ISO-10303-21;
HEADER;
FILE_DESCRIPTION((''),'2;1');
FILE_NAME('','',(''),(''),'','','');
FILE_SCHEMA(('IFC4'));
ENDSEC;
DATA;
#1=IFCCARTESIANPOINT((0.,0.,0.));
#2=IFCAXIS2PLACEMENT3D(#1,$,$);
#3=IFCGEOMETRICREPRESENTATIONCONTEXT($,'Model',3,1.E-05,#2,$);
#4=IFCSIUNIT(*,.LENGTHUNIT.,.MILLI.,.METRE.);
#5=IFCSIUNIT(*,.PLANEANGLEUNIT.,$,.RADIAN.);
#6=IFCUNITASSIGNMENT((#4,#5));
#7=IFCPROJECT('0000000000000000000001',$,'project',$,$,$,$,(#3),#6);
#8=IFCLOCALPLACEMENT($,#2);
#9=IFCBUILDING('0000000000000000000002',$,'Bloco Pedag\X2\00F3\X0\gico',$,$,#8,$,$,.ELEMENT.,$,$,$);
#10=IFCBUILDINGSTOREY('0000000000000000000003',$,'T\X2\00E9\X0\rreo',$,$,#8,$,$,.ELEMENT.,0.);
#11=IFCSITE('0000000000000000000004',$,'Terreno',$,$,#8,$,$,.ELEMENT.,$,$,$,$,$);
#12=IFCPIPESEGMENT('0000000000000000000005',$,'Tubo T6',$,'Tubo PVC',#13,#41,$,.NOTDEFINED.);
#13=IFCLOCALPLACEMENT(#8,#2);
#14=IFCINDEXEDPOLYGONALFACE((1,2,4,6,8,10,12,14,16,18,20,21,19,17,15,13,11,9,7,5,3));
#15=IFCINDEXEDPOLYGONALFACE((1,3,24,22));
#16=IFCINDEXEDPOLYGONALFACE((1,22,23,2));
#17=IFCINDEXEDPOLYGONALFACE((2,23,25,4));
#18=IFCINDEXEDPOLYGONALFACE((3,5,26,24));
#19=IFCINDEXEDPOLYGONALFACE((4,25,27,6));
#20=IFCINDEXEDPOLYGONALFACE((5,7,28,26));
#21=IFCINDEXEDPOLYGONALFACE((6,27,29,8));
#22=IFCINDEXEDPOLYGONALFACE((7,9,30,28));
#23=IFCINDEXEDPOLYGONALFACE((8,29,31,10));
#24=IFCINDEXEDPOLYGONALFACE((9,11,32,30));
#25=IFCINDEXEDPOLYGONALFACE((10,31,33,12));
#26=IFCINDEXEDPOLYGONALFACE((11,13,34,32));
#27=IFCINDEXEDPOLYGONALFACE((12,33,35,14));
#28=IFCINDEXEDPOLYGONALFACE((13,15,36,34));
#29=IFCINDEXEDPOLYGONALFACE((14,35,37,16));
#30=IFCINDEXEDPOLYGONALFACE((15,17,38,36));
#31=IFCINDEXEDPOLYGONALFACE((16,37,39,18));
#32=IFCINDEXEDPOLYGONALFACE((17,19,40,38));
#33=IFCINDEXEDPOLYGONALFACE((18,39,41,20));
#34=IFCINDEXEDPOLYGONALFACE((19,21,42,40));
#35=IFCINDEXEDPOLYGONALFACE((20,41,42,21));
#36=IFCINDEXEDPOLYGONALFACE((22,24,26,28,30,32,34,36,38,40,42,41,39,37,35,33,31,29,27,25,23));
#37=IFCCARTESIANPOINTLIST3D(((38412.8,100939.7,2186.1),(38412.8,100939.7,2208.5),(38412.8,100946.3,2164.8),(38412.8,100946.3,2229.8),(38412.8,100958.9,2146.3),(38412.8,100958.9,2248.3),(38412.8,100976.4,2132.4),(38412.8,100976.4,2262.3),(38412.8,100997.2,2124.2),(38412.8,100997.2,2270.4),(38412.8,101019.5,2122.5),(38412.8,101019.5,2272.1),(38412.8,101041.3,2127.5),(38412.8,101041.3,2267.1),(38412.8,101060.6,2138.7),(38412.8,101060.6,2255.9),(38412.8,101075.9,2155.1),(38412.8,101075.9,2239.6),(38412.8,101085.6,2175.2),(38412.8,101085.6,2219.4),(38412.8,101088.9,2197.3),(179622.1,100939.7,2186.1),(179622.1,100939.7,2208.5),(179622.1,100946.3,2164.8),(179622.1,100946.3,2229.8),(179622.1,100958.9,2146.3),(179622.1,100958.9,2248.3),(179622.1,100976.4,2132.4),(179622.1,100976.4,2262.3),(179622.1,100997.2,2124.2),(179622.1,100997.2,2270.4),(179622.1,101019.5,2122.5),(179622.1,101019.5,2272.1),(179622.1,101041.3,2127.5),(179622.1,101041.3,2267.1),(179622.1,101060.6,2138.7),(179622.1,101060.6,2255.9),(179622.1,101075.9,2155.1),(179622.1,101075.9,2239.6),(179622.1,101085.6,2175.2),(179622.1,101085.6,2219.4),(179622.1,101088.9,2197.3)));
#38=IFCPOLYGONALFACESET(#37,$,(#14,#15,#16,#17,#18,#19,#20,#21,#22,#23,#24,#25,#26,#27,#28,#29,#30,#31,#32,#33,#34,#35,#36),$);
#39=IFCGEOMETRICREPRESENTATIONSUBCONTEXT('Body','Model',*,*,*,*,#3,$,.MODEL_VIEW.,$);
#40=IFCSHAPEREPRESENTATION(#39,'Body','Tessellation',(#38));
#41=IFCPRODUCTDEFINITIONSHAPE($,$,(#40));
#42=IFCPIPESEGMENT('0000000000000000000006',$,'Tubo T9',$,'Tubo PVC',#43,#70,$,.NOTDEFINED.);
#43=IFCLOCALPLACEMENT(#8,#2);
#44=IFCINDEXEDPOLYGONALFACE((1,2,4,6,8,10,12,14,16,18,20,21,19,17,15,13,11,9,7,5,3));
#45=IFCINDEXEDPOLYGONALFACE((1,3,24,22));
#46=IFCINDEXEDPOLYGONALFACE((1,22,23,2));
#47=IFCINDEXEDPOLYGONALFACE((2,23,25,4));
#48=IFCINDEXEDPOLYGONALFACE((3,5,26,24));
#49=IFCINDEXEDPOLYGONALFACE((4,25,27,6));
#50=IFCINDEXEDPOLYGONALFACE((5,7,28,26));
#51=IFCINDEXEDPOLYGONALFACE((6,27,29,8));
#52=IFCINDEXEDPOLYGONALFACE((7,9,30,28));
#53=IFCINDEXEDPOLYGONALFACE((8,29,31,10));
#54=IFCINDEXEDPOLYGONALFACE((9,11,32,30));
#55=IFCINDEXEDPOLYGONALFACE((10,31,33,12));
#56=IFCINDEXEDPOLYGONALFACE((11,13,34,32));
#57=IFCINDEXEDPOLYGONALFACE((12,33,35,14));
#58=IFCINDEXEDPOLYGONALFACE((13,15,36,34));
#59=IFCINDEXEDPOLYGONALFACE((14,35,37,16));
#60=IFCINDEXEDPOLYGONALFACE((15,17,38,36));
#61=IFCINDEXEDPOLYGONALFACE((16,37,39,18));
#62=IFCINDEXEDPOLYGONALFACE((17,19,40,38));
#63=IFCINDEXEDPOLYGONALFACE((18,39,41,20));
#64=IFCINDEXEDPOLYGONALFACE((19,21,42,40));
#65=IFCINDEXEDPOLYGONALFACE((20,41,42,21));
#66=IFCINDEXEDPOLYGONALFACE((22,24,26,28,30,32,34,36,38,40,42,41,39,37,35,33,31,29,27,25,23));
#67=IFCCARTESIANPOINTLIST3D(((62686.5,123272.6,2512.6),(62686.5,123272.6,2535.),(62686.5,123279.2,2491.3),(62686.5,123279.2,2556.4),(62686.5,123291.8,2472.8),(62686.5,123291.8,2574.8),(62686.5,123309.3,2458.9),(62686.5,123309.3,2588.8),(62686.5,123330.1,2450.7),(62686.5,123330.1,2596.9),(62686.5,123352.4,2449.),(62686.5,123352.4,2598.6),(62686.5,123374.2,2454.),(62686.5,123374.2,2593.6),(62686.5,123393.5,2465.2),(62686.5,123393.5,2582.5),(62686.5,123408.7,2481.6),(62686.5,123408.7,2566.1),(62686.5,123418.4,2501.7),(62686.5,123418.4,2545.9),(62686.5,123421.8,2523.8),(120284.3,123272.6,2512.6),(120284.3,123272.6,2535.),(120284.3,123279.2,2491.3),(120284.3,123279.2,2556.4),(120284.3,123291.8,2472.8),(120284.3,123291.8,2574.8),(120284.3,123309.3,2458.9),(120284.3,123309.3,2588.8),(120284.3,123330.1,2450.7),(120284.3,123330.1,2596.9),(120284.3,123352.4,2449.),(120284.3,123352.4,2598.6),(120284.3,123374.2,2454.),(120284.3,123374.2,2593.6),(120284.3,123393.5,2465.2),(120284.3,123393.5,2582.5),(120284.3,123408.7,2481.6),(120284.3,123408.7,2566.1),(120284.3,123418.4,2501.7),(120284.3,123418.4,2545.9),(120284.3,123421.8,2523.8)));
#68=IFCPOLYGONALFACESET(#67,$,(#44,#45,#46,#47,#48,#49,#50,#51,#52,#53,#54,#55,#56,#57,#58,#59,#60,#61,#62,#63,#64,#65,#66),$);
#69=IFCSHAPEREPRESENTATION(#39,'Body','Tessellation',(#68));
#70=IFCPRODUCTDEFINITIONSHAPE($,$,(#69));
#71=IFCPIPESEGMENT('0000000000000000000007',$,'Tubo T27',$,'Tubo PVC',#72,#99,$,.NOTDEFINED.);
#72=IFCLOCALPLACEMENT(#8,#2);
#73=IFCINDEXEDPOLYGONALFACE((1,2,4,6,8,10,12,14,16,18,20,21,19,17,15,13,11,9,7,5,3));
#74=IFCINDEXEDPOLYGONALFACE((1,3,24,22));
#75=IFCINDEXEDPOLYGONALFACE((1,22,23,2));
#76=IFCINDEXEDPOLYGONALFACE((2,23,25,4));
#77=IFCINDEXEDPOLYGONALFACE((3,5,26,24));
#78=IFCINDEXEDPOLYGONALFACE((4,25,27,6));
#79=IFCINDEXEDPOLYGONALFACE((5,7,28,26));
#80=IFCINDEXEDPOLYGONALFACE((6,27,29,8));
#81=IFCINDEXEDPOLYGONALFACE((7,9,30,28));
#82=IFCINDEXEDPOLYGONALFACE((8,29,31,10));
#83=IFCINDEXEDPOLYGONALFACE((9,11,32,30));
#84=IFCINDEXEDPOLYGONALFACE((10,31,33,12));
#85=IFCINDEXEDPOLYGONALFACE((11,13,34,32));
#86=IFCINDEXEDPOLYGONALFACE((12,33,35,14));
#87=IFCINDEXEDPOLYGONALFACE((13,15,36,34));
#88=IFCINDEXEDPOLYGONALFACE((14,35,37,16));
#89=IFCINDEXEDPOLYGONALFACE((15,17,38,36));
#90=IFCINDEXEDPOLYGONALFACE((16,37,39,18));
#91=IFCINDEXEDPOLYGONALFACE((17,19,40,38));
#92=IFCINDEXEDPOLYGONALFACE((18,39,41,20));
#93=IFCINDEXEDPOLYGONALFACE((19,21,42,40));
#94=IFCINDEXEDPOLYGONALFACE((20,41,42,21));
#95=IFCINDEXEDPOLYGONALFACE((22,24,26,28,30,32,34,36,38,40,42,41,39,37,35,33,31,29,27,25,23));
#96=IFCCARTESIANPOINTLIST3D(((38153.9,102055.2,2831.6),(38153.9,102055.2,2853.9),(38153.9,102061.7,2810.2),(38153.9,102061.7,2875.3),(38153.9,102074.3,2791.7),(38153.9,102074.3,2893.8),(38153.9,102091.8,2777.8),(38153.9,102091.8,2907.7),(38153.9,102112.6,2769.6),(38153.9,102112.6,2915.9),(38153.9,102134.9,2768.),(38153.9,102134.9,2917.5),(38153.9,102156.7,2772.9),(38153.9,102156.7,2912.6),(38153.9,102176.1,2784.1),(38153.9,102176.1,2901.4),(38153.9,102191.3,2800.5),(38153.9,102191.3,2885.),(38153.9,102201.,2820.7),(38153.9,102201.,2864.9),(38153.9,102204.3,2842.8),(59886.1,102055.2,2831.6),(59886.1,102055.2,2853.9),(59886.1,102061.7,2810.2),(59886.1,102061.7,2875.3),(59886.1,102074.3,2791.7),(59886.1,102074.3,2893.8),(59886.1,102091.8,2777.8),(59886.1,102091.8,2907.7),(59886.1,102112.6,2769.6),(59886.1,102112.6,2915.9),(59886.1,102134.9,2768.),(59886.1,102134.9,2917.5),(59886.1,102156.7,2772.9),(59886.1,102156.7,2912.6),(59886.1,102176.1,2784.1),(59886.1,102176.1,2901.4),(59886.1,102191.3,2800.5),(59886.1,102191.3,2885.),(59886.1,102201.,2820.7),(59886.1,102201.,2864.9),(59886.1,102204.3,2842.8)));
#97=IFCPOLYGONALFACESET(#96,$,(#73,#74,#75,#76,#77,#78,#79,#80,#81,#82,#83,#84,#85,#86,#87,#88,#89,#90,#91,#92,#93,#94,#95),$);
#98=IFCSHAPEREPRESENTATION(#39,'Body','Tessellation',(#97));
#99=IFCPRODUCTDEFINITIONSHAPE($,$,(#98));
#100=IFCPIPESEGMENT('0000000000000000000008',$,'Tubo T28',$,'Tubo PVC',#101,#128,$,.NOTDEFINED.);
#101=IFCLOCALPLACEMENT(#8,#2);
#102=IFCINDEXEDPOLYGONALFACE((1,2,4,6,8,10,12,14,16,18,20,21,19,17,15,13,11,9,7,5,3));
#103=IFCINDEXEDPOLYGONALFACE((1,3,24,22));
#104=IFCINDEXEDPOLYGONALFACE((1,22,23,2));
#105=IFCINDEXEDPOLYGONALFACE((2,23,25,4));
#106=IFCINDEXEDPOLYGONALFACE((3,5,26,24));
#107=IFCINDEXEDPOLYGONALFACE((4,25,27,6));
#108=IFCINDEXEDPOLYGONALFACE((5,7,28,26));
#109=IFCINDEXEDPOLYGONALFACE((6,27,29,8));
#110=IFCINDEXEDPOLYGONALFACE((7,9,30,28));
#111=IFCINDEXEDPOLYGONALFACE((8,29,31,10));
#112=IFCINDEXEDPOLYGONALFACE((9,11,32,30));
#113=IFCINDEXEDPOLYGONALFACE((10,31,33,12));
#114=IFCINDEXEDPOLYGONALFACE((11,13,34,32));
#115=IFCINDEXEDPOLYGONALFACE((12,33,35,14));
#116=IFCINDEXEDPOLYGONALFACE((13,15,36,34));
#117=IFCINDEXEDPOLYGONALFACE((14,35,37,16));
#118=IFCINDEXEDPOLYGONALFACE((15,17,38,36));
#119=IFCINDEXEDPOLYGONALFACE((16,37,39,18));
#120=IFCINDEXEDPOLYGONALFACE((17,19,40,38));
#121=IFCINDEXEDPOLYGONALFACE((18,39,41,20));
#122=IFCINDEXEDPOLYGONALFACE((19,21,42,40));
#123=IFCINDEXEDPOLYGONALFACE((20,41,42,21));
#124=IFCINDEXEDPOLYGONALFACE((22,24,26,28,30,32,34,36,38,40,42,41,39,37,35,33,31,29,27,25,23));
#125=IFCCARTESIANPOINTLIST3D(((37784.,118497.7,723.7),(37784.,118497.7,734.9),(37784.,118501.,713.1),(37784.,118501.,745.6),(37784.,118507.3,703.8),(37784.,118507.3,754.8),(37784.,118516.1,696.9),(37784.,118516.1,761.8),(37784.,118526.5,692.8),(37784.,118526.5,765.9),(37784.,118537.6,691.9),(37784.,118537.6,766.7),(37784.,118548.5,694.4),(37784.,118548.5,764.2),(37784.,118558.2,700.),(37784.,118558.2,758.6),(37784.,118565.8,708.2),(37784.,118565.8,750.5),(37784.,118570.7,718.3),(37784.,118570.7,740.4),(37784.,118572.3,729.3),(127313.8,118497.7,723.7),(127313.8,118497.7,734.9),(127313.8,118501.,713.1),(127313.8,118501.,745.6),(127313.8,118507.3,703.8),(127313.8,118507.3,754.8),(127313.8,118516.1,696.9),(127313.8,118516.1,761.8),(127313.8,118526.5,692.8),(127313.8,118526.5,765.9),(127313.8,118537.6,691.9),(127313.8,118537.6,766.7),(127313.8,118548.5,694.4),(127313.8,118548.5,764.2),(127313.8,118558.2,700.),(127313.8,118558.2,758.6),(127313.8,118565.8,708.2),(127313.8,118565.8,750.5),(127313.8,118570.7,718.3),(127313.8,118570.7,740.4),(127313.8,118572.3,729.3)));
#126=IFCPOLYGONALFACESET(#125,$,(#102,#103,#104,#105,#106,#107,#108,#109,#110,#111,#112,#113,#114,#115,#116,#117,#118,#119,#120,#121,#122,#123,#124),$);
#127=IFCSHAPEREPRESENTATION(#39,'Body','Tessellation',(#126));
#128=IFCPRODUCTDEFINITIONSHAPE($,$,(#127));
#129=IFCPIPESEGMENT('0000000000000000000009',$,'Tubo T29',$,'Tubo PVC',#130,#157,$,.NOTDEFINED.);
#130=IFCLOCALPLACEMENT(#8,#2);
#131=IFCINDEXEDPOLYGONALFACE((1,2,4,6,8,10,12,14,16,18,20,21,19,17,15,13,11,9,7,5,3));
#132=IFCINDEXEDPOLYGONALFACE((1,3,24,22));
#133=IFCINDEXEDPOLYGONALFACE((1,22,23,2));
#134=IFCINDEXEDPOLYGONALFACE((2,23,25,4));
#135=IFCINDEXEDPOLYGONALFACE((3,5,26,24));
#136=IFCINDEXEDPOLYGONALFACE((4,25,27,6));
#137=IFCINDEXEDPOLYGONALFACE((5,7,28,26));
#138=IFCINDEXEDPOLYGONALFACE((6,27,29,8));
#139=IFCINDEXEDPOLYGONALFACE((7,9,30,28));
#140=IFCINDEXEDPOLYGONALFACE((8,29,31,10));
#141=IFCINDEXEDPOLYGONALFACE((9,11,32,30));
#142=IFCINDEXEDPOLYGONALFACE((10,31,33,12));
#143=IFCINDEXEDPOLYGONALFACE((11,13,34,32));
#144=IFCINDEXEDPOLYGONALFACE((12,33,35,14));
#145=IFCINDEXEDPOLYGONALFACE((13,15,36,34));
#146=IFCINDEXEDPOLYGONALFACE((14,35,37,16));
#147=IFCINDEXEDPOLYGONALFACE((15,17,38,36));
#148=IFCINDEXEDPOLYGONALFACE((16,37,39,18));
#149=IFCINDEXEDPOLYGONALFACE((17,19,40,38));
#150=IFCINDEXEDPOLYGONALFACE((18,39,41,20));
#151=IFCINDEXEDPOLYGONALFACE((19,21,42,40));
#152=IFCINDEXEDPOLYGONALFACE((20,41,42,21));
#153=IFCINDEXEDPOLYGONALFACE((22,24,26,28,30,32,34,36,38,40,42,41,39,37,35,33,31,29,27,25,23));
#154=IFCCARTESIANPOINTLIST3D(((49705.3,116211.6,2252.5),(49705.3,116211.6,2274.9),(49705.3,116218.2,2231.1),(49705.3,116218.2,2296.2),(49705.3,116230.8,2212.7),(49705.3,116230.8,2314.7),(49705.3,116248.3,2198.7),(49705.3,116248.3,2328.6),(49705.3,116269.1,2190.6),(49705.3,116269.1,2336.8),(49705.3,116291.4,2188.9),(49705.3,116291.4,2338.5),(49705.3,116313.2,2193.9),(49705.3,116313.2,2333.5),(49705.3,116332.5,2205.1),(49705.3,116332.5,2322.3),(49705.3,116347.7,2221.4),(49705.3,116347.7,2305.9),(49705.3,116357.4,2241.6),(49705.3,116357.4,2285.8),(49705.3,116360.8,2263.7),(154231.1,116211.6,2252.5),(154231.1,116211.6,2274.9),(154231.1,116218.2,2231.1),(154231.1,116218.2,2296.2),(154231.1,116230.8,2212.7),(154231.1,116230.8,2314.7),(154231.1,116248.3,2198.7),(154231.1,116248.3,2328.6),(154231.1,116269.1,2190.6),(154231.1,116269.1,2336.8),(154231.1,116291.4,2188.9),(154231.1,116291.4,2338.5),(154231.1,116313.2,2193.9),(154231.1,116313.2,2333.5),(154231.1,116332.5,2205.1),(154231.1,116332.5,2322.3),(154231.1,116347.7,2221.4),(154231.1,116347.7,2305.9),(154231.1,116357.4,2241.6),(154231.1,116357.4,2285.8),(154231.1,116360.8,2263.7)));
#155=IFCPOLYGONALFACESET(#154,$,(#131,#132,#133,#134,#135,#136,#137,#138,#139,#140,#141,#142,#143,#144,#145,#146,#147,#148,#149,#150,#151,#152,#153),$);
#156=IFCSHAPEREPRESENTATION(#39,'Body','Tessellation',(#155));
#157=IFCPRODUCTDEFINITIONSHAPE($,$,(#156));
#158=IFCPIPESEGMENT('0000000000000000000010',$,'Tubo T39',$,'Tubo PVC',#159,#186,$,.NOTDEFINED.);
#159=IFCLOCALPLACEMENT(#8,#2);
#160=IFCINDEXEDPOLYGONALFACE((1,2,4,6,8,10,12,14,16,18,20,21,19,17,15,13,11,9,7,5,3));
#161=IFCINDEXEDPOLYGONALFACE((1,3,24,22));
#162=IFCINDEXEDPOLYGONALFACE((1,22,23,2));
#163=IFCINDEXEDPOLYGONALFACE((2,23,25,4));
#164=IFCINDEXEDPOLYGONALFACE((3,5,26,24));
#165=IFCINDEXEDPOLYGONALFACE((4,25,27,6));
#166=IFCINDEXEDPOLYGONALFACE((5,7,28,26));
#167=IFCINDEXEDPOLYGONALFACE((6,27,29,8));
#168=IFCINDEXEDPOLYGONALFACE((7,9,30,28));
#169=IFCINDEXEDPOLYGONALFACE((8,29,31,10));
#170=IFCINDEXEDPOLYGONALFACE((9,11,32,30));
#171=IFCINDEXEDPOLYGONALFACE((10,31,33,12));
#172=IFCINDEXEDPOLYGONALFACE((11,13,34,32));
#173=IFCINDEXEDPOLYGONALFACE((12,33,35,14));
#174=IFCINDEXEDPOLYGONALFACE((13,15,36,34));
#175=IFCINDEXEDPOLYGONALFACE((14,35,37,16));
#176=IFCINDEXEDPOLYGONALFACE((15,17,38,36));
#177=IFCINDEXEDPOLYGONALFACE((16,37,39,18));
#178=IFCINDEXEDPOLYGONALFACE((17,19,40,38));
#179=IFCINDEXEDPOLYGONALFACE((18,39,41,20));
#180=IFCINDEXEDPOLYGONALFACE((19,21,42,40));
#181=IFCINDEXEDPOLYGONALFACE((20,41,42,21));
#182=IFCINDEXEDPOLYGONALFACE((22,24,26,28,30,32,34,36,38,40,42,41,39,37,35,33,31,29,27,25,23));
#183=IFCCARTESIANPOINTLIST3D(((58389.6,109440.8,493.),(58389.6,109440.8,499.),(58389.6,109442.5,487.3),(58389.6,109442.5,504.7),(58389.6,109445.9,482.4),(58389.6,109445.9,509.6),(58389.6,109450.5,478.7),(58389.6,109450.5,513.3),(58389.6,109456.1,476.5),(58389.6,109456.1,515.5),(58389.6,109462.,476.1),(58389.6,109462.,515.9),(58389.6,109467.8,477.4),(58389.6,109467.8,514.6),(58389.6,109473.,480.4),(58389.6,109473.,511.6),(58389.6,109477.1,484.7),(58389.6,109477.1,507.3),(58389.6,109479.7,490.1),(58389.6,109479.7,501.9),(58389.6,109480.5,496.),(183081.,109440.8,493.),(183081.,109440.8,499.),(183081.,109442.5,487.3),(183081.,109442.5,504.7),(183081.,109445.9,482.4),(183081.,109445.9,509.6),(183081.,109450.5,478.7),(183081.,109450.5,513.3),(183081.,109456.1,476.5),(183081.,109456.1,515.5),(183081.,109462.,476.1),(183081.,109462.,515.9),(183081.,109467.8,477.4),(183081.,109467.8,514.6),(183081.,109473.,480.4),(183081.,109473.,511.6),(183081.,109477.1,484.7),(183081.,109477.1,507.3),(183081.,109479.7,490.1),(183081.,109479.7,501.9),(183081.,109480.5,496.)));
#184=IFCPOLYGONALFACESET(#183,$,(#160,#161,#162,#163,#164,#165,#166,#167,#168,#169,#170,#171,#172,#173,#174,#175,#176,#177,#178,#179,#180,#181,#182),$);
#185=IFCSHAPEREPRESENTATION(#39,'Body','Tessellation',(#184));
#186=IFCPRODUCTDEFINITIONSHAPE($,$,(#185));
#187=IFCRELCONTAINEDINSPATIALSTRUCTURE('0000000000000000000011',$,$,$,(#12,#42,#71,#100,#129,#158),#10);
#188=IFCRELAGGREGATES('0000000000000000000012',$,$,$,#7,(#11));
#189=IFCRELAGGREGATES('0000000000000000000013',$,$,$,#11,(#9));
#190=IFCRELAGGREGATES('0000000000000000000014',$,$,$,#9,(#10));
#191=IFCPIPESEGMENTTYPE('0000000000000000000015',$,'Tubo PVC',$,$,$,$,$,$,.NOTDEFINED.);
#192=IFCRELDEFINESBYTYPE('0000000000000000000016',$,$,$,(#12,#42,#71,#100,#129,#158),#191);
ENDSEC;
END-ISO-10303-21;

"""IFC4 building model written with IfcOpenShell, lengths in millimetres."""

from ifc_helpers import new_model, si_unit, frame, origin, origin_2d, place, context, subcontext, project, spatial, circle, extrude, type_object, element, save


model = new_model("IFC4")

# Units and contexts
model_context = context("Model", 3, precision=1e-05, world=origin())
body_context = subcontext(model_context, "Body", "Model", "MODEL_VIEW")
ifc_project = project(units=[si_unit("LENGTHUNIT", "METRE", prefix="MILLI"), si_unit("PLANEANGLEUNIT", "RADIAN")], contexts=[model_context])

# Site, building, storey
placement = place(None, origin())
site = spatial("IfcSite", under=ifc_project, at=placement, Name="Terreno", CompositionType="ELEMENT")
building = spatial("IfcBuilding", under=site, at=placement, Name="Bloco Pedagógico", CompositionType="ELEMENT")
storey = spatial("IfcBuildingStorey", under=building, at=placement, Name="Térreo", CompositionType="ELEMENT", Elevation=0.0)

# Pipe segments
pipe_segment_type = type_object("IfcPipeSegmentType", Name="Tubo PVC", PredefinedType="NOTDEFINED")
pipe_segment_1_placement = place(None, frame((38412.8, 101013.9, 2197.3), z_axis=(1.0, 0.0, 0.0), x_axis=(0.0, 1.0, 0.0)))
element("IfcPipeSegment", 1, at=pipe_segment_1_placement, inside=storey, type_object=pipe_segment_type, Name="Tubo T6", ObjectType="Tubo PVC", PredefinedType="NOTDEFINED", context=body_context, shape_type="SweptSolid", body=[
    extrude(circle(Radius=75.0, at=origin_2d()), None, (0.0, 0.0, 1.0), 141209.3),
])
pipe_segment_2_placement = place(None, frame((62686.5, 123346.8, 2523.8), z_axis=(1.0, 0.0, 0.0), x_axis=(0.0, 1.0, 0.0)))
element("IfcPipeSegment", 2, at=pipe_segment_2_placement, inside=storey, type_object=pipe_segment_type, Name="Tubo T9", ObjectType="Tubo PVC", PredefinedType="NOTDEFINED", context=body_context, shape_type="SweptSolid", body=[
    extrude(circle(Radius=75.0, at=origin_2d()), None, (0.0, 0.0, 1.0), 57597.8),
])
pipe_segment_3_placement = place(None, frame((38153.9, 102129.3, 2842.8), z_axis=(1.0, 0.0, 0.0), x_axis=(0.0, 1.0, 0.0)))
element("IfcPipeSegment", 3, at=pipe_segment_3_placement, inside=storey, type_object=pipe_segment_type, Name="Tubo T27", ObjectType="Tubo PVC", PredefinedType="NOTDEFINED", context=body_context, shape_type="SweptSolid", body=[
    extrude(circle(Radius=75.0, at=origin_2d()), None, (0.0, 0.0, 1.0), 21732.2),
])
pipe_segment_4_placement = place(None, frame((37784.0, 118534.8, 729.3), z_axis=(1.0, 0.0, 0.0), x_axis=(0.0, 1.0, 0.0)))
element("IfcPipeSegment", 4, at=pipe_segment_4_placement, inside=storey, type_object=pipe_segment_type, Name="Tubo T28", ObjectType="Tubo PVC", PredefinedType="NOTDEFINED", context=body_context, shape_type="SweptSolid", body=[
    extrude(circle(Radius=37.5, at=origin_2d()), None, (0.0, 0.0, 1.0), 89529.7),
])
pipe_segment_5_placement = place(None, frame((49705.3, 116285.8, 2263.7), z_axis=(1.0, 0.0, 0.0), x_axis=(0.0, 1.0, 0.0)))
element("IfcPipeSegment", 5, at=pipe_segment_5_placement, inside=storey, type_object=pipe_segment_type, Name="Tubo T29", ObjectType="Tubo PVC", PredefinedType="NOTDEFINED", context=body_context, shape_type="SweptSolid", body=[
    extrude(circle(Radius=75.0, at=origin_2d()), None, (0.0, 0.0, 1.0), 104525.8),
])
pipe_segment_6_placement = place(None, frame((58389.6, 109460.5, 496.0), z_axis=(1.0, 0.0, 0.0), x_axis=(0.0, 1.0, 0.0)))
element("IfcPipeSegment", 6, at=pipe_segment_6_placement, inside=storey, type_object=pipe_segment_type, Name="Tubo T39", ObjectType="Tubo PVC", PredefinedType="NOTDEFINED", context=body_context, shape_type="SweptSolid", body=[
    extrude(circle(Radius=20.0, at=origin_2d()), None, (0.0, 0.0, 1.0), 124691.3),
])

save(model, "model.ifc")
